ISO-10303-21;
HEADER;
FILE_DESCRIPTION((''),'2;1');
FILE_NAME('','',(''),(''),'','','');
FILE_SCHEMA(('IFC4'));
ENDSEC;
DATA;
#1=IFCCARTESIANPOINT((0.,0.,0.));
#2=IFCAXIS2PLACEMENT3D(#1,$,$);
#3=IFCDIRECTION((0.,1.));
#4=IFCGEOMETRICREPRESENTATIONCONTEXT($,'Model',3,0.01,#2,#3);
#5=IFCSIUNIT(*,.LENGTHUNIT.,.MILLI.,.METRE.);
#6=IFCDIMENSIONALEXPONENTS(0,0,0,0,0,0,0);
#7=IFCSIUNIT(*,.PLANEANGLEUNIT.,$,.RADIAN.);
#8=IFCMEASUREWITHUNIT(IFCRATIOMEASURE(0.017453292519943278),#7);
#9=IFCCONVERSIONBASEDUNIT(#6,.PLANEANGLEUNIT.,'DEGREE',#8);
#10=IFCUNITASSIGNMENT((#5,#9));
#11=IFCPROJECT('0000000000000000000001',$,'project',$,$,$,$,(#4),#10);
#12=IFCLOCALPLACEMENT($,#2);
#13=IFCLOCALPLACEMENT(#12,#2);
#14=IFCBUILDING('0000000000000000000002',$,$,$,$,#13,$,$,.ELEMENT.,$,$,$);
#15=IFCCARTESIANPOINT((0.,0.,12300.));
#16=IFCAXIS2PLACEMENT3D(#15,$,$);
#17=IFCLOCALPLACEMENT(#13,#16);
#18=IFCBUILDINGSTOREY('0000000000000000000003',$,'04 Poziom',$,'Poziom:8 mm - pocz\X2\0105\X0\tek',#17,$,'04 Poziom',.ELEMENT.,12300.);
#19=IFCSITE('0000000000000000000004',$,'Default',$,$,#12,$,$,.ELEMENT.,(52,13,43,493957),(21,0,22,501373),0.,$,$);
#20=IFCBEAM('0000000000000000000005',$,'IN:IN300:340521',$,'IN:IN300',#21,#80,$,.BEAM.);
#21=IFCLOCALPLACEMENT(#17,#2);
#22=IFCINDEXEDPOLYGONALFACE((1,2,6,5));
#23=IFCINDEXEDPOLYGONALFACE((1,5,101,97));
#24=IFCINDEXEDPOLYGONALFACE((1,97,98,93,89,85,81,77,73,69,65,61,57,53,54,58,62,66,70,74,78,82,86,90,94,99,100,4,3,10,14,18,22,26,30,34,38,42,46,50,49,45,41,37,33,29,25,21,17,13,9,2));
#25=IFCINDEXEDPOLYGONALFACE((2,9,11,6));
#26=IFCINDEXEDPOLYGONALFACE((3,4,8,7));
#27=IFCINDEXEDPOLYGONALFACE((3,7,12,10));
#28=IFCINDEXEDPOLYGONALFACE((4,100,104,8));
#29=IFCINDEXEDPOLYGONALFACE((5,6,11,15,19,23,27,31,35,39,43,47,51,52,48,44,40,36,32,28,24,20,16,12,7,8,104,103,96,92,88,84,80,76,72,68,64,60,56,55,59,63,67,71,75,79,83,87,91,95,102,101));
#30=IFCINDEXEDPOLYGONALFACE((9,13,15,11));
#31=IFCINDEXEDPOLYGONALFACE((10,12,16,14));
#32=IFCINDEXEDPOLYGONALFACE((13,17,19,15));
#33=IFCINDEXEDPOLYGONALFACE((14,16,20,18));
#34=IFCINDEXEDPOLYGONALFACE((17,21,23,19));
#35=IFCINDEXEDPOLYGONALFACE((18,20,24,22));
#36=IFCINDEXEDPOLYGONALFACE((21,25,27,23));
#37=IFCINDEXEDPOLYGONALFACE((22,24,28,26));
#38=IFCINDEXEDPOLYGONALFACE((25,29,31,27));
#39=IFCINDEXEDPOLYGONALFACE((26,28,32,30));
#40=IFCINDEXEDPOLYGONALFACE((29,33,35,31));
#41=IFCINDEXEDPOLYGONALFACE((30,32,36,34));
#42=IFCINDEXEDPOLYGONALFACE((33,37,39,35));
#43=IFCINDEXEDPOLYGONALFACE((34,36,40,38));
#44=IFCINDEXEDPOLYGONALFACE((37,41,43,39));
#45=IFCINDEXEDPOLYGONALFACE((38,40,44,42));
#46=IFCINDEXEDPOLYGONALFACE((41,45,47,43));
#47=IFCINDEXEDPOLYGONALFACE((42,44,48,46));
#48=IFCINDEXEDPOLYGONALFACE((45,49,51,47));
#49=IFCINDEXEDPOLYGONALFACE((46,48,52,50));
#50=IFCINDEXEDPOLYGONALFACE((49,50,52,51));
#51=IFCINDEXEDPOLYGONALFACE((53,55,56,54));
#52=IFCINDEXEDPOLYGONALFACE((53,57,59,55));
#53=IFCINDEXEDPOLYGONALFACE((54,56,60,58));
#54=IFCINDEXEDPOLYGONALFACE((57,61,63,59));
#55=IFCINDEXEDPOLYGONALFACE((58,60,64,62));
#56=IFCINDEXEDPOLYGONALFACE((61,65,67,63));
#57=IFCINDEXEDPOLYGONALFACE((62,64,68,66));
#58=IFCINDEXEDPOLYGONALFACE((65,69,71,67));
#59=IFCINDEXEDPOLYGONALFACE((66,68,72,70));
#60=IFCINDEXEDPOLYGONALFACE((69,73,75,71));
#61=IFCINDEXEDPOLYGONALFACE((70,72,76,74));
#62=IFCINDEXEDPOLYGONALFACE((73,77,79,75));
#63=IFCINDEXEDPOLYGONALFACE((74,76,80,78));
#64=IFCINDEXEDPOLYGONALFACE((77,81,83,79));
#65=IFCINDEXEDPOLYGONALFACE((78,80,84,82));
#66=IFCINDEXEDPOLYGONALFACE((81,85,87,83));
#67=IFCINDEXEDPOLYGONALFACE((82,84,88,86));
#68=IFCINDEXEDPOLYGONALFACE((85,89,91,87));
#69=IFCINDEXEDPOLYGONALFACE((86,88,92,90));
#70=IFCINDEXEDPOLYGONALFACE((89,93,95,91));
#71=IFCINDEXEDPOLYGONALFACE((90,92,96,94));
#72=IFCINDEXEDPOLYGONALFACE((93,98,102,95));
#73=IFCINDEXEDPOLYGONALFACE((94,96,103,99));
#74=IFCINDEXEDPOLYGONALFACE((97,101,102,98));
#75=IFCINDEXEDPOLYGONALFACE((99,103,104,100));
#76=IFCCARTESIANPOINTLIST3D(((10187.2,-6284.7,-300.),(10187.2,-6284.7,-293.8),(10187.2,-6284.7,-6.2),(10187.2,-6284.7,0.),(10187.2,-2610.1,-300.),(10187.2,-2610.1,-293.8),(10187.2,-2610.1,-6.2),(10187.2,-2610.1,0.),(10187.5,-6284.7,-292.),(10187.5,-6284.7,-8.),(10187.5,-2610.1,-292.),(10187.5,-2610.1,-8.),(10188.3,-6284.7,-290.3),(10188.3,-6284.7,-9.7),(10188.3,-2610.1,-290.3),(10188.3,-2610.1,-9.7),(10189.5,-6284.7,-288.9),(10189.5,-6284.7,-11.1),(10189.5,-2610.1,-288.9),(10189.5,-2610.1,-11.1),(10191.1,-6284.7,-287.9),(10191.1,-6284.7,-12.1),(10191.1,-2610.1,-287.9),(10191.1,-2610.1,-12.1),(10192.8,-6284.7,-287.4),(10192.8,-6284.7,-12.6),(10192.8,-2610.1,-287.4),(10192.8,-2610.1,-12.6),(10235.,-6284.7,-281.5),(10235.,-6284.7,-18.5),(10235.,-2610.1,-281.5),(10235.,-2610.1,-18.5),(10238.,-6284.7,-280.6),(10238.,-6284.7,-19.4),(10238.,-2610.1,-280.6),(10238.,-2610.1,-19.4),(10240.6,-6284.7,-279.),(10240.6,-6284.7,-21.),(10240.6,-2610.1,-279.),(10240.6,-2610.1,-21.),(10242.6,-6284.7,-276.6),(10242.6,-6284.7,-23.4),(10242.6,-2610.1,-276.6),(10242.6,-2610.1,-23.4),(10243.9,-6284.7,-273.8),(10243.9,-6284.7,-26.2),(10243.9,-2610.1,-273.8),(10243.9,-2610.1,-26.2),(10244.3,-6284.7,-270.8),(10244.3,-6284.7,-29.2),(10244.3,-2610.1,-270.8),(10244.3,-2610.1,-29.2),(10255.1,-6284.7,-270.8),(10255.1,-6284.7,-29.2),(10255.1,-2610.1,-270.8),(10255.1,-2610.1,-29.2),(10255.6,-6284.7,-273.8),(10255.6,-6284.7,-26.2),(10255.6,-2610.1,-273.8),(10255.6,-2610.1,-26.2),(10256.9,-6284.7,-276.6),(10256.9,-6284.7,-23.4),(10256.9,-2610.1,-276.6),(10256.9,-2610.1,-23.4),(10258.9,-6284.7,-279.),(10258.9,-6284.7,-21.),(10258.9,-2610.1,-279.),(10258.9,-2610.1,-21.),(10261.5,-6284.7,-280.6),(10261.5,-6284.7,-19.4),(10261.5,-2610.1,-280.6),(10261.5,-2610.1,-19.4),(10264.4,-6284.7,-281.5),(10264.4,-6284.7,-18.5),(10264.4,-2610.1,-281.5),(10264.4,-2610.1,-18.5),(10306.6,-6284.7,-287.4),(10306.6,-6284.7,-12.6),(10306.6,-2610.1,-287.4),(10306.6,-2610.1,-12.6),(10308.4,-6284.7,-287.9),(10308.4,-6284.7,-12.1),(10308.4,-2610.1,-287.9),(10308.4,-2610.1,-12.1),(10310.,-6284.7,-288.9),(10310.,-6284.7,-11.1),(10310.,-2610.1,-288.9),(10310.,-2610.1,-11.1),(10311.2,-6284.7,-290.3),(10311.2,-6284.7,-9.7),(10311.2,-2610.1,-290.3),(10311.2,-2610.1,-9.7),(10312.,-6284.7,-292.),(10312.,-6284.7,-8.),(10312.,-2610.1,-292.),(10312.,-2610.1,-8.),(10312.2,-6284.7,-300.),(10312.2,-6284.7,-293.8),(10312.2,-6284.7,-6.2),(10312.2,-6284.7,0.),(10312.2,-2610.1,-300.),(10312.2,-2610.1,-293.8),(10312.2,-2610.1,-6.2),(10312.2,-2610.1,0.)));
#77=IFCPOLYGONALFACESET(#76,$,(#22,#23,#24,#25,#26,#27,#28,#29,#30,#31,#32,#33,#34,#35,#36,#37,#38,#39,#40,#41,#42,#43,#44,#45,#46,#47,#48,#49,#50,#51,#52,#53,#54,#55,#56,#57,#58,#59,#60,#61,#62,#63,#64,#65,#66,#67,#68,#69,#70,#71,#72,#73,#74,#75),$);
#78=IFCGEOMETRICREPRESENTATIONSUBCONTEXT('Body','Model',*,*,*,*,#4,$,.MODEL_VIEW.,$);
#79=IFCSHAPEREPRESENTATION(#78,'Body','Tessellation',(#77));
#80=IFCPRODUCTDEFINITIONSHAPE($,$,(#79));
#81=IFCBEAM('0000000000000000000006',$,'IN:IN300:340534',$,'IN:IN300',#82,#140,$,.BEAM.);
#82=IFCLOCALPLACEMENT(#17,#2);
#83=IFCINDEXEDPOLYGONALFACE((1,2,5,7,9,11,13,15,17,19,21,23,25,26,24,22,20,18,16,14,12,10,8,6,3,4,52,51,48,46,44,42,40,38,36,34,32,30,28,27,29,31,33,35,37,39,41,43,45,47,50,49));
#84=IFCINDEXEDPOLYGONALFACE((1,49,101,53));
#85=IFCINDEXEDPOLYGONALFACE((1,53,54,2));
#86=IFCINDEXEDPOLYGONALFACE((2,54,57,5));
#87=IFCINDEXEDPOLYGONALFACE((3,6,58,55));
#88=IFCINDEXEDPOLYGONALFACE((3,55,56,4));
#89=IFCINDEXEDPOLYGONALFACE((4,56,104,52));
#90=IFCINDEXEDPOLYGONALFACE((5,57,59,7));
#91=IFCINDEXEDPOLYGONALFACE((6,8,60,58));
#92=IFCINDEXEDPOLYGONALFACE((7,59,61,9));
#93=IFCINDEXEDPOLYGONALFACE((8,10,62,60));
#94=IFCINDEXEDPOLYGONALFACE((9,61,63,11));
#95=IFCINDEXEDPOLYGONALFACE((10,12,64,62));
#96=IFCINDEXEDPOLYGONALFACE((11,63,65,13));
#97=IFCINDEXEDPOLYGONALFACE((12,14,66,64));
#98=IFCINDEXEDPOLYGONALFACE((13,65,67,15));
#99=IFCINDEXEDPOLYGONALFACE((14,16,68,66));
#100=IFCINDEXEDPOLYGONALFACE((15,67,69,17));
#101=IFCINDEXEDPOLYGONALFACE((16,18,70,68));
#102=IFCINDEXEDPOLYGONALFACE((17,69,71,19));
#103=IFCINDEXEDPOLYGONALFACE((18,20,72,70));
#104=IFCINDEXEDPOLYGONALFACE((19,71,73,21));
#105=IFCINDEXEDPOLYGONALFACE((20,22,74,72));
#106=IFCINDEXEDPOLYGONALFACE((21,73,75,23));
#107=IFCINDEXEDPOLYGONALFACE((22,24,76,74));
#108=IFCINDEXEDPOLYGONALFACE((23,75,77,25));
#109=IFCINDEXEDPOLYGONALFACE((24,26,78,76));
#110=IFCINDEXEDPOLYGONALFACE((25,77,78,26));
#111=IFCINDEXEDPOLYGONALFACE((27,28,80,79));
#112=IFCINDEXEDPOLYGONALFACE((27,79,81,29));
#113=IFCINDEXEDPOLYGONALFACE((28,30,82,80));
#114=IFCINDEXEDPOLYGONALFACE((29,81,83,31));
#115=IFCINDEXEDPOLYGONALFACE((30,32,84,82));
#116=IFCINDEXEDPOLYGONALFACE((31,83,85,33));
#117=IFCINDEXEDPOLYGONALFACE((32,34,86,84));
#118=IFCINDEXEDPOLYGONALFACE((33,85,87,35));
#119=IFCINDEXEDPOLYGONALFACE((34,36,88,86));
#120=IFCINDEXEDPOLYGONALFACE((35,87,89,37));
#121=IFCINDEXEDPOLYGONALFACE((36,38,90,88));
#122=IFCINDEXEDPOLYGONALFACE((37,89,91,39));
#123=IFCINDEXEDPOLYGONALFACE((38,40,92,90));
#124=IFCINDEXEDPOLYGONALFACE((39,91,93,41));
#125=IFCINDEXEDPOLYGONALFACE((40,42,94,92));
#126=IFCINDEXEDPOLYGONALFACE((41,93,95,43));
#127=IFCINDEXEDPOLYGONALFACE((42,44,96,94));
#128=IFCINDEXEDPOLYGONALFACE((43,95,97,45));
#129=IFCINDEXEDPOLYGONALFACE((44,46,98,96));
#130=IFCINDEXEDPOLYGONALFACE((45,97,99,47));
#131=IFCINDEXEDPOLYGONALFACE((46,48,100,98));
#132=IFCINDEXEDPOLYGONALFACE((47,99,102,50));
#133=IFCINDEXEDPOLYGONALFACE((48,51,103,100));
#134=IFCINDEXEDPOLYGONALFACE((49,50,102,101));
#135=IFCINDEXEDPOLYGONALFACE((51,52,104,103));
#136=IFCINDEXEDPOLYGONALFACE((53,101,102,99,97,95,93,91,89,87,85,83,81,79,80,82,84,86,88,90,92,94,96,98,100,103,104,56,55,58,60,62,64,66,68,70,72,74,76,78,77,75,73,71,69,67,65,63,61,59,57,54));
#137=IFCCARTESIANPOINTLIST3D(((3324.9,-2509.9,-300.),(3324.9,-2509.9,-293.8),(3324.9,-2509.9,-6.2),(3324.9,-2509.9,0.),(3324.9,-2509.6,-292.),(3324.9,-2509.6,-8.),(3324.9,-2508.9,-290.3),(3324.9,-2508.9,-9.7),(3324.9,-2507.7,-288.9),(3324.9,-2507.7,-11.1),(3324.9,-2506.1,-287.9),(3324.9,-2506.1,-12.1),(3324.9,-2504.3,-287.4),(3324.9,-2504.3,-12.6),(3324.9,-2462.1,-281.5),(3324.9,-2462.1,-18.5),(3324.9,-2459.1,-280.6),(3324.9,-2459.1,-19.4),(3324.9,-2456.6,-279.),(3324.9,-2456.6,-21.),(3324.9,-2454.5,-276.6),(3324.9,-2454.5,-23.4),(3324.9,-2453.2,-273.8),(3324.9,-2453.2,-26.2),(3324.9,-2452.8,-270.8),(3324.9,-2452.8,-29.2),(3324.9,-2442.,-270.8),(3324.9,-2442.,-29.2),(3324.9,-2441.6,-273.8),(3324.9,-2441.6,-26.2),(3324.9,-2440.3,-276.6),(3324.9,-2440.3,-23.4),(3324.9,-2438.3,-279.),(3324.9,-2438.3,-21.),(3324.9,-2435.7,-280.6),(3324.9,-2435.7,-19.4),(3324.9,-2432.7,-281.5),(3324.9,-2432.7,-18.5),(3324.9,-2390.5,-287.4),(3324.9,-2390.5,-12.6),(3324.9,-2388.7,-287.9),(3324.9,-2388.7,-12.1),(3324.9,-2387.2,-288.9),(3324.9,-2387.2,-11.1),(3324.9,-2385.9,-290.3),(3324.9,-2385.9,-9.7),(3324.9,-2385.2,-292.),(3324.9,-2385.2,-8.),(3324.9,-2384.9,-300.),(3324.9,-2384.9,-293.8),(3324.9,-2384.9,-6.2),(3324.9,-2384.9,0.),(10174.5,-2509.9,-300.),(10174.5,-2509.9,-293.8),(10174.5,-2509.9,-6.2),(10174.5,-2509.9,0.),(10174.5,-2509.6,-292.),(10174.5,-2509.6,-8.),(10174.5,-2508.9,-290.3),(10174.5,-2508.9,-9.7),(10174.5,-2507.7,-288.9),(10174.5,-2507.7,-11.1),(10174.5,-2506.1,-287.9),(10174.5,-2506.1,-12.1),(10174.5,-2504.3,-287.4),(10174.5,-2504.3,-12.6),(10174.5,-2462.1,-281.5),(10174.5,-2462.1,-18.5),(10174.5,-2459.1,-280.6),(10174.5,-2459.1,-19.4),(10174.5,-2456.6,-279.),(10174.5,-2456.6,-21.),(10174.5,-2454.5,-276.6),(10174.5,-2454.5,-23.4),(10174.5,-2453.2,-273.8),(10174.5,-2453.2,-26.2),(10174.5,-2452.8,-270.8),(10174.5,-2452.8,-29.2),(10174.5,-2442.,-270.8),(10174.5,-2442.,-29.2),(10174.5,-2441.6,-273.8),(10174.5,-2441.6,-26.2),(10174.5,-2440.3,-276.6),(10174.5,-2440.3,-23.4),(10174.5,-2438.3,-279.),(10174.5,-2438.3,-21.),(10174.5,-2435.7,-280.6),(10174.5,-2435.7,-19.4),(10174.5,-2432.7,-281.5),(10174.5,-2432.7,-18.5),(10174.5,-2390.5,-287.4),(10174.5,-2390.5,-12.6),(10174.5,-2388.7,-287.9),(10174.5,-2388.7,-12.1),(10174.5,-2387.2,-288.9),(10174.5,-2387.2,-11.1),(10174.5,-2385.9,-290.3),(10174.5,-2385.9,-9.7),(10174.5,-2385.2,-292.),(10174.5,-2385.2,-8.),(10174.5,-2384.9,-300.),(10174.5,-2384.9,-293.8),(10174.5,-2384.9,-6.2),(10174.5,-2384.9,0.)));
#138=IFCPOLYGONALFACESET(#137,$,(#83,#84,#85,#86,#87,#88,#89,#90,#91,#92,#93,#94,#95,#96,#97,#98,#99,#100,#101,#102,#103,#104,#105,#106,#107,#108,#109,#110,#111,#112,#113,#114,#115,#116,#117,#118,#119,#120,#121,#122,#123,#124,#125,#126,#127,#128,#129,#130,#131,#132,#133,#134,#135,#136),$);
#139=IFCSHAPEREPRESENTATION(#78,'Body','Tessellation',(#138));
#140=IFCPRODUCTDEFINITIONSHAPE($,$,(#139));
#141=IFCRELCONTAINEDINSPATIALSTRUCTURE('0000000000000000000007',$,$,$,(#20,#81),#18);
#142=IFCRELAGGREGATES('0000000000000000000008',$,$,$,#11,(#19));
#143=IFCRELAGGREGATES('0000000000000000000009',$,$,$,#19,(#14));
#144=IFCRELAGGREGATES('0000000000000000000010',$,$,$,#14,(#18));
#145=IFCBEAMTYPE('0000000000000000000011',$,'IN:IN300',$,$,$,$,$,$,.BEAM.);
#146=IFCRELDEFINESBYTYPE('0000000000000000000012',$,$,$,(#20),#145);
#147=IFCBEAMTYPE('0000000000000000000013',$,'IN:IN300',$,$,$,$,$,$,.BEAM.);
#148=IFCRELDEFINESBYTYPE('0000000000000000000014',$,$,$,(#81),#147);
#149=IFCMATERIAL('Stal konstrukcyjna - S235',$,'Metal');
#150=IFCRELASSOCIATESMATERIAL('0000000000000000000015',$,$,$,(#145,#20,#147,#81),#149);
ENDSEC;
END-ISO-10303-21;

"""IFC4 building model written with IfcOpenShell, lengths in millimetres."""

from ifc_helpers import new_model, entity, si_unit, converted_unit, direction, frame, origin, place, context, subcontext, project, spatial, line, arc, indexed_curve, outline, extrude, source, transform, mapped, material, type_object, type_shapes, element, save


model = new_model("IFC4")

# Units and contexts
model_context = context("Model", 3, precision=0.01, world=origin(), true_north=direction((0.0, 1.0)))
body_context = subcontext(model_context, "Body", "Model", "MODEL_VIEW")
ifc_project = project(units=[si_unit("LENGTHUNIT", "METRE", prefix="MILLI"), converted_unit("PLANEANGLEUNIT", "DEGREE", entity("IfcRatioMeasure", 0.017453292519943278), si_unit("PLANEANGLEUNIT", "RADIAN"), dimensions=[0, 0, 0, 0, 0, 0, 0])], contexts=[model_context])

# Site, building, storey
site_placement = place(None, origin())
site = spatial("IfcSite", under=ifc_project, at=site_placement, Name="Default", CompositionType="ELEMENT", RefLatitude=(52, 13, 43, 493957), RefLongitude=(21, 0, 22, 501373), RefElevation=0.0)
building_placement = place(site_placement, origin())
building = spatial("IfcBuilding", under=site, at=building_placement, CompositionType="ELEMENT")
storey_placement = place(building_placement, frame((0.0, 0.0, 12300.0)))
storey = spatial("IfcBuildingStorey", under=building, at=storey_placement, Name="04 Poziom", ObjectType="Poziom:8 mm - początek", LongName="04 Poziom", CompositionType="ELEMENT", Elevation=12300.0)

# Shared definitions
ifc_material = material(Name="Stal konstrukcyjna - S235", Category="Metal")

# Beams
beam_type_1 = type_object("IfcBeamType", Name="IN:IN300", PredefinedType="BEAM", material=ifc_material)
shared_shape_1 = source(origin(), body_context, "Body", "SweptSolid", [
    extrude(outline(indexed_curve([(143.8, -62.5), (150.0, -62.5), (150.0, 62.5), (143.8, 62.5), (139.6, 60.9), (137.4, 56.9), (131.5, 14.7), (127.9, 8.1), (120.8, 5.4), (-120.8, 5.4), (-127.9, 8.1), (-131.5, 14.7), (-137.4, 56.9), (-139.6, 60.9), (-143.8, 62.5), (-150.0, 62.5), (-150.0, -62.5), (-143.8, -62.5), (-139.6, -60.9), (-137.4, -56.9), (-131.5, -14.7), (-127.9, -8.1), (-120.8, -5.4), (120.8, -5.4), (127.9, -8.1), (131.5, -14.7), (137.4, -56.9), (139.6, -60.9)], segments=[line(1, 2, 3, 4), arc(4, 5, 6), line(6, 7), arc(7, 8, 9), line(9, 10), arc(10, 11, 12), line(12, 13), arc(13, 14, 15), line(15, 16, 17, 18), arc(18, 19, 20), line(20, 21), arc(21, 22, 23), line(23, 24), arc(24, 25, 26), line(26, 27), arc(27, 28, 1)], self_intersect=False)), frame((-1837.3, 0.0, 0.0), z_axis=(1.0, 0.0, 0.0), x_axis=(0.0, 0.0, -1.0)), (0.0, 0.0, 1.0), 3674.6),
])
type_shapes(beam_type_1, [shared_shape_1])
for number, where, z_axis, x_axis, name in (
    (1, (10249.7, -4447.4, -150.0), (0.0, 0.0, 1.0), (0.0, -1.0, 0.0), "IN:IN300:340521"),
):
    element("IfcBeam", number, at=place(storey_placement, frame(where, z_axis=z_axis, x_axis=x_axis)), inside=storey, type_object=beam_type_1, material=ifc_material, Name=name, ObjectType="IN:IN300", PredefinedType="BEAM", context=body_context, shape_type="MappedRepresentation", body=[
        mapped(shared_shape_1, transform((0.0, 0.0, 0.0), scale=1.0)),
    ])
beam_type_2 = type_object("IfcBeamType", Name="IN:IN300", PredefinedType="BEAM", material=ifc_material)
shared_shape_2 = source(origin(), body_context, "Body", "SweptSolid", [
    extrude(outline(indexed_curve([(143.8, -62.5), (150.0, -62.5), (150.0, 62.5), (143.8, 62.5), (139.6, 60.9), (137.4, 56.9), (131.5, 14.7), (127.9, 8.1), (120.8, 5.4), (-120.8, 5.4), (-127.9, 8.1), (-131.5, 14.7), (-137.4, 56.9), (-139.6, 60.9), (-143.8, 62.5), (-150.0, 62.5), (-150.0, -62.5), (-143.8, -62.5), (-139.6, -60.9), (-137.4, -56.9), (-131.5, -14.7), (-127.9, -8.1), (-120.8, -5.4), (120.8, -5.4), (127.9, -8.1), (131.5, -14.7), (137.4, -56.9), (139.6, -60.9)], segments=[line(1, 2, 3, 4), arc(4, 5, 6), line(6, 7), arc(7, 8, 9), line(9, 10), arc(10, 11, 12), line(12, 13), arc(13, 14, 15), line(15, 16, 17, 18), arc(18, 19, 20), line(20, 21), arc(21, 22, 23), line(23, 24), arc(24, 25, 26), line(26, 27), arc(27, 28, 1)], self_intersect=False)), frame((-3424.8, 0.0, 0.0), z_axis=(1.0, 0.0, 0.0), x_axis=(0.0, 0.0, -1.0)), (0.0, 0.0, 1.0), 6849.6),
])
type_shapes(beam_type_2, [shared_shape_2])
for number, where, name in (
    (2, (6749.7, -2447.4, -150.0), "IN:IN300:340534"),
):
    element("IfcBeam", number, at=place(storey_placement, frame(where)), inside=storey, type_object=beam_type_2, material=ifc_material, Name=name, ObjectType="IN:IN300", PredefinedType="BEAM", context=body_context, shape_type="MappedRepresentation", body=[
        mapped(shared_shape_2, transform((0.0, 0.0, 0.0), scale=1.0)),
    ])

save(model, "model.ifc")
